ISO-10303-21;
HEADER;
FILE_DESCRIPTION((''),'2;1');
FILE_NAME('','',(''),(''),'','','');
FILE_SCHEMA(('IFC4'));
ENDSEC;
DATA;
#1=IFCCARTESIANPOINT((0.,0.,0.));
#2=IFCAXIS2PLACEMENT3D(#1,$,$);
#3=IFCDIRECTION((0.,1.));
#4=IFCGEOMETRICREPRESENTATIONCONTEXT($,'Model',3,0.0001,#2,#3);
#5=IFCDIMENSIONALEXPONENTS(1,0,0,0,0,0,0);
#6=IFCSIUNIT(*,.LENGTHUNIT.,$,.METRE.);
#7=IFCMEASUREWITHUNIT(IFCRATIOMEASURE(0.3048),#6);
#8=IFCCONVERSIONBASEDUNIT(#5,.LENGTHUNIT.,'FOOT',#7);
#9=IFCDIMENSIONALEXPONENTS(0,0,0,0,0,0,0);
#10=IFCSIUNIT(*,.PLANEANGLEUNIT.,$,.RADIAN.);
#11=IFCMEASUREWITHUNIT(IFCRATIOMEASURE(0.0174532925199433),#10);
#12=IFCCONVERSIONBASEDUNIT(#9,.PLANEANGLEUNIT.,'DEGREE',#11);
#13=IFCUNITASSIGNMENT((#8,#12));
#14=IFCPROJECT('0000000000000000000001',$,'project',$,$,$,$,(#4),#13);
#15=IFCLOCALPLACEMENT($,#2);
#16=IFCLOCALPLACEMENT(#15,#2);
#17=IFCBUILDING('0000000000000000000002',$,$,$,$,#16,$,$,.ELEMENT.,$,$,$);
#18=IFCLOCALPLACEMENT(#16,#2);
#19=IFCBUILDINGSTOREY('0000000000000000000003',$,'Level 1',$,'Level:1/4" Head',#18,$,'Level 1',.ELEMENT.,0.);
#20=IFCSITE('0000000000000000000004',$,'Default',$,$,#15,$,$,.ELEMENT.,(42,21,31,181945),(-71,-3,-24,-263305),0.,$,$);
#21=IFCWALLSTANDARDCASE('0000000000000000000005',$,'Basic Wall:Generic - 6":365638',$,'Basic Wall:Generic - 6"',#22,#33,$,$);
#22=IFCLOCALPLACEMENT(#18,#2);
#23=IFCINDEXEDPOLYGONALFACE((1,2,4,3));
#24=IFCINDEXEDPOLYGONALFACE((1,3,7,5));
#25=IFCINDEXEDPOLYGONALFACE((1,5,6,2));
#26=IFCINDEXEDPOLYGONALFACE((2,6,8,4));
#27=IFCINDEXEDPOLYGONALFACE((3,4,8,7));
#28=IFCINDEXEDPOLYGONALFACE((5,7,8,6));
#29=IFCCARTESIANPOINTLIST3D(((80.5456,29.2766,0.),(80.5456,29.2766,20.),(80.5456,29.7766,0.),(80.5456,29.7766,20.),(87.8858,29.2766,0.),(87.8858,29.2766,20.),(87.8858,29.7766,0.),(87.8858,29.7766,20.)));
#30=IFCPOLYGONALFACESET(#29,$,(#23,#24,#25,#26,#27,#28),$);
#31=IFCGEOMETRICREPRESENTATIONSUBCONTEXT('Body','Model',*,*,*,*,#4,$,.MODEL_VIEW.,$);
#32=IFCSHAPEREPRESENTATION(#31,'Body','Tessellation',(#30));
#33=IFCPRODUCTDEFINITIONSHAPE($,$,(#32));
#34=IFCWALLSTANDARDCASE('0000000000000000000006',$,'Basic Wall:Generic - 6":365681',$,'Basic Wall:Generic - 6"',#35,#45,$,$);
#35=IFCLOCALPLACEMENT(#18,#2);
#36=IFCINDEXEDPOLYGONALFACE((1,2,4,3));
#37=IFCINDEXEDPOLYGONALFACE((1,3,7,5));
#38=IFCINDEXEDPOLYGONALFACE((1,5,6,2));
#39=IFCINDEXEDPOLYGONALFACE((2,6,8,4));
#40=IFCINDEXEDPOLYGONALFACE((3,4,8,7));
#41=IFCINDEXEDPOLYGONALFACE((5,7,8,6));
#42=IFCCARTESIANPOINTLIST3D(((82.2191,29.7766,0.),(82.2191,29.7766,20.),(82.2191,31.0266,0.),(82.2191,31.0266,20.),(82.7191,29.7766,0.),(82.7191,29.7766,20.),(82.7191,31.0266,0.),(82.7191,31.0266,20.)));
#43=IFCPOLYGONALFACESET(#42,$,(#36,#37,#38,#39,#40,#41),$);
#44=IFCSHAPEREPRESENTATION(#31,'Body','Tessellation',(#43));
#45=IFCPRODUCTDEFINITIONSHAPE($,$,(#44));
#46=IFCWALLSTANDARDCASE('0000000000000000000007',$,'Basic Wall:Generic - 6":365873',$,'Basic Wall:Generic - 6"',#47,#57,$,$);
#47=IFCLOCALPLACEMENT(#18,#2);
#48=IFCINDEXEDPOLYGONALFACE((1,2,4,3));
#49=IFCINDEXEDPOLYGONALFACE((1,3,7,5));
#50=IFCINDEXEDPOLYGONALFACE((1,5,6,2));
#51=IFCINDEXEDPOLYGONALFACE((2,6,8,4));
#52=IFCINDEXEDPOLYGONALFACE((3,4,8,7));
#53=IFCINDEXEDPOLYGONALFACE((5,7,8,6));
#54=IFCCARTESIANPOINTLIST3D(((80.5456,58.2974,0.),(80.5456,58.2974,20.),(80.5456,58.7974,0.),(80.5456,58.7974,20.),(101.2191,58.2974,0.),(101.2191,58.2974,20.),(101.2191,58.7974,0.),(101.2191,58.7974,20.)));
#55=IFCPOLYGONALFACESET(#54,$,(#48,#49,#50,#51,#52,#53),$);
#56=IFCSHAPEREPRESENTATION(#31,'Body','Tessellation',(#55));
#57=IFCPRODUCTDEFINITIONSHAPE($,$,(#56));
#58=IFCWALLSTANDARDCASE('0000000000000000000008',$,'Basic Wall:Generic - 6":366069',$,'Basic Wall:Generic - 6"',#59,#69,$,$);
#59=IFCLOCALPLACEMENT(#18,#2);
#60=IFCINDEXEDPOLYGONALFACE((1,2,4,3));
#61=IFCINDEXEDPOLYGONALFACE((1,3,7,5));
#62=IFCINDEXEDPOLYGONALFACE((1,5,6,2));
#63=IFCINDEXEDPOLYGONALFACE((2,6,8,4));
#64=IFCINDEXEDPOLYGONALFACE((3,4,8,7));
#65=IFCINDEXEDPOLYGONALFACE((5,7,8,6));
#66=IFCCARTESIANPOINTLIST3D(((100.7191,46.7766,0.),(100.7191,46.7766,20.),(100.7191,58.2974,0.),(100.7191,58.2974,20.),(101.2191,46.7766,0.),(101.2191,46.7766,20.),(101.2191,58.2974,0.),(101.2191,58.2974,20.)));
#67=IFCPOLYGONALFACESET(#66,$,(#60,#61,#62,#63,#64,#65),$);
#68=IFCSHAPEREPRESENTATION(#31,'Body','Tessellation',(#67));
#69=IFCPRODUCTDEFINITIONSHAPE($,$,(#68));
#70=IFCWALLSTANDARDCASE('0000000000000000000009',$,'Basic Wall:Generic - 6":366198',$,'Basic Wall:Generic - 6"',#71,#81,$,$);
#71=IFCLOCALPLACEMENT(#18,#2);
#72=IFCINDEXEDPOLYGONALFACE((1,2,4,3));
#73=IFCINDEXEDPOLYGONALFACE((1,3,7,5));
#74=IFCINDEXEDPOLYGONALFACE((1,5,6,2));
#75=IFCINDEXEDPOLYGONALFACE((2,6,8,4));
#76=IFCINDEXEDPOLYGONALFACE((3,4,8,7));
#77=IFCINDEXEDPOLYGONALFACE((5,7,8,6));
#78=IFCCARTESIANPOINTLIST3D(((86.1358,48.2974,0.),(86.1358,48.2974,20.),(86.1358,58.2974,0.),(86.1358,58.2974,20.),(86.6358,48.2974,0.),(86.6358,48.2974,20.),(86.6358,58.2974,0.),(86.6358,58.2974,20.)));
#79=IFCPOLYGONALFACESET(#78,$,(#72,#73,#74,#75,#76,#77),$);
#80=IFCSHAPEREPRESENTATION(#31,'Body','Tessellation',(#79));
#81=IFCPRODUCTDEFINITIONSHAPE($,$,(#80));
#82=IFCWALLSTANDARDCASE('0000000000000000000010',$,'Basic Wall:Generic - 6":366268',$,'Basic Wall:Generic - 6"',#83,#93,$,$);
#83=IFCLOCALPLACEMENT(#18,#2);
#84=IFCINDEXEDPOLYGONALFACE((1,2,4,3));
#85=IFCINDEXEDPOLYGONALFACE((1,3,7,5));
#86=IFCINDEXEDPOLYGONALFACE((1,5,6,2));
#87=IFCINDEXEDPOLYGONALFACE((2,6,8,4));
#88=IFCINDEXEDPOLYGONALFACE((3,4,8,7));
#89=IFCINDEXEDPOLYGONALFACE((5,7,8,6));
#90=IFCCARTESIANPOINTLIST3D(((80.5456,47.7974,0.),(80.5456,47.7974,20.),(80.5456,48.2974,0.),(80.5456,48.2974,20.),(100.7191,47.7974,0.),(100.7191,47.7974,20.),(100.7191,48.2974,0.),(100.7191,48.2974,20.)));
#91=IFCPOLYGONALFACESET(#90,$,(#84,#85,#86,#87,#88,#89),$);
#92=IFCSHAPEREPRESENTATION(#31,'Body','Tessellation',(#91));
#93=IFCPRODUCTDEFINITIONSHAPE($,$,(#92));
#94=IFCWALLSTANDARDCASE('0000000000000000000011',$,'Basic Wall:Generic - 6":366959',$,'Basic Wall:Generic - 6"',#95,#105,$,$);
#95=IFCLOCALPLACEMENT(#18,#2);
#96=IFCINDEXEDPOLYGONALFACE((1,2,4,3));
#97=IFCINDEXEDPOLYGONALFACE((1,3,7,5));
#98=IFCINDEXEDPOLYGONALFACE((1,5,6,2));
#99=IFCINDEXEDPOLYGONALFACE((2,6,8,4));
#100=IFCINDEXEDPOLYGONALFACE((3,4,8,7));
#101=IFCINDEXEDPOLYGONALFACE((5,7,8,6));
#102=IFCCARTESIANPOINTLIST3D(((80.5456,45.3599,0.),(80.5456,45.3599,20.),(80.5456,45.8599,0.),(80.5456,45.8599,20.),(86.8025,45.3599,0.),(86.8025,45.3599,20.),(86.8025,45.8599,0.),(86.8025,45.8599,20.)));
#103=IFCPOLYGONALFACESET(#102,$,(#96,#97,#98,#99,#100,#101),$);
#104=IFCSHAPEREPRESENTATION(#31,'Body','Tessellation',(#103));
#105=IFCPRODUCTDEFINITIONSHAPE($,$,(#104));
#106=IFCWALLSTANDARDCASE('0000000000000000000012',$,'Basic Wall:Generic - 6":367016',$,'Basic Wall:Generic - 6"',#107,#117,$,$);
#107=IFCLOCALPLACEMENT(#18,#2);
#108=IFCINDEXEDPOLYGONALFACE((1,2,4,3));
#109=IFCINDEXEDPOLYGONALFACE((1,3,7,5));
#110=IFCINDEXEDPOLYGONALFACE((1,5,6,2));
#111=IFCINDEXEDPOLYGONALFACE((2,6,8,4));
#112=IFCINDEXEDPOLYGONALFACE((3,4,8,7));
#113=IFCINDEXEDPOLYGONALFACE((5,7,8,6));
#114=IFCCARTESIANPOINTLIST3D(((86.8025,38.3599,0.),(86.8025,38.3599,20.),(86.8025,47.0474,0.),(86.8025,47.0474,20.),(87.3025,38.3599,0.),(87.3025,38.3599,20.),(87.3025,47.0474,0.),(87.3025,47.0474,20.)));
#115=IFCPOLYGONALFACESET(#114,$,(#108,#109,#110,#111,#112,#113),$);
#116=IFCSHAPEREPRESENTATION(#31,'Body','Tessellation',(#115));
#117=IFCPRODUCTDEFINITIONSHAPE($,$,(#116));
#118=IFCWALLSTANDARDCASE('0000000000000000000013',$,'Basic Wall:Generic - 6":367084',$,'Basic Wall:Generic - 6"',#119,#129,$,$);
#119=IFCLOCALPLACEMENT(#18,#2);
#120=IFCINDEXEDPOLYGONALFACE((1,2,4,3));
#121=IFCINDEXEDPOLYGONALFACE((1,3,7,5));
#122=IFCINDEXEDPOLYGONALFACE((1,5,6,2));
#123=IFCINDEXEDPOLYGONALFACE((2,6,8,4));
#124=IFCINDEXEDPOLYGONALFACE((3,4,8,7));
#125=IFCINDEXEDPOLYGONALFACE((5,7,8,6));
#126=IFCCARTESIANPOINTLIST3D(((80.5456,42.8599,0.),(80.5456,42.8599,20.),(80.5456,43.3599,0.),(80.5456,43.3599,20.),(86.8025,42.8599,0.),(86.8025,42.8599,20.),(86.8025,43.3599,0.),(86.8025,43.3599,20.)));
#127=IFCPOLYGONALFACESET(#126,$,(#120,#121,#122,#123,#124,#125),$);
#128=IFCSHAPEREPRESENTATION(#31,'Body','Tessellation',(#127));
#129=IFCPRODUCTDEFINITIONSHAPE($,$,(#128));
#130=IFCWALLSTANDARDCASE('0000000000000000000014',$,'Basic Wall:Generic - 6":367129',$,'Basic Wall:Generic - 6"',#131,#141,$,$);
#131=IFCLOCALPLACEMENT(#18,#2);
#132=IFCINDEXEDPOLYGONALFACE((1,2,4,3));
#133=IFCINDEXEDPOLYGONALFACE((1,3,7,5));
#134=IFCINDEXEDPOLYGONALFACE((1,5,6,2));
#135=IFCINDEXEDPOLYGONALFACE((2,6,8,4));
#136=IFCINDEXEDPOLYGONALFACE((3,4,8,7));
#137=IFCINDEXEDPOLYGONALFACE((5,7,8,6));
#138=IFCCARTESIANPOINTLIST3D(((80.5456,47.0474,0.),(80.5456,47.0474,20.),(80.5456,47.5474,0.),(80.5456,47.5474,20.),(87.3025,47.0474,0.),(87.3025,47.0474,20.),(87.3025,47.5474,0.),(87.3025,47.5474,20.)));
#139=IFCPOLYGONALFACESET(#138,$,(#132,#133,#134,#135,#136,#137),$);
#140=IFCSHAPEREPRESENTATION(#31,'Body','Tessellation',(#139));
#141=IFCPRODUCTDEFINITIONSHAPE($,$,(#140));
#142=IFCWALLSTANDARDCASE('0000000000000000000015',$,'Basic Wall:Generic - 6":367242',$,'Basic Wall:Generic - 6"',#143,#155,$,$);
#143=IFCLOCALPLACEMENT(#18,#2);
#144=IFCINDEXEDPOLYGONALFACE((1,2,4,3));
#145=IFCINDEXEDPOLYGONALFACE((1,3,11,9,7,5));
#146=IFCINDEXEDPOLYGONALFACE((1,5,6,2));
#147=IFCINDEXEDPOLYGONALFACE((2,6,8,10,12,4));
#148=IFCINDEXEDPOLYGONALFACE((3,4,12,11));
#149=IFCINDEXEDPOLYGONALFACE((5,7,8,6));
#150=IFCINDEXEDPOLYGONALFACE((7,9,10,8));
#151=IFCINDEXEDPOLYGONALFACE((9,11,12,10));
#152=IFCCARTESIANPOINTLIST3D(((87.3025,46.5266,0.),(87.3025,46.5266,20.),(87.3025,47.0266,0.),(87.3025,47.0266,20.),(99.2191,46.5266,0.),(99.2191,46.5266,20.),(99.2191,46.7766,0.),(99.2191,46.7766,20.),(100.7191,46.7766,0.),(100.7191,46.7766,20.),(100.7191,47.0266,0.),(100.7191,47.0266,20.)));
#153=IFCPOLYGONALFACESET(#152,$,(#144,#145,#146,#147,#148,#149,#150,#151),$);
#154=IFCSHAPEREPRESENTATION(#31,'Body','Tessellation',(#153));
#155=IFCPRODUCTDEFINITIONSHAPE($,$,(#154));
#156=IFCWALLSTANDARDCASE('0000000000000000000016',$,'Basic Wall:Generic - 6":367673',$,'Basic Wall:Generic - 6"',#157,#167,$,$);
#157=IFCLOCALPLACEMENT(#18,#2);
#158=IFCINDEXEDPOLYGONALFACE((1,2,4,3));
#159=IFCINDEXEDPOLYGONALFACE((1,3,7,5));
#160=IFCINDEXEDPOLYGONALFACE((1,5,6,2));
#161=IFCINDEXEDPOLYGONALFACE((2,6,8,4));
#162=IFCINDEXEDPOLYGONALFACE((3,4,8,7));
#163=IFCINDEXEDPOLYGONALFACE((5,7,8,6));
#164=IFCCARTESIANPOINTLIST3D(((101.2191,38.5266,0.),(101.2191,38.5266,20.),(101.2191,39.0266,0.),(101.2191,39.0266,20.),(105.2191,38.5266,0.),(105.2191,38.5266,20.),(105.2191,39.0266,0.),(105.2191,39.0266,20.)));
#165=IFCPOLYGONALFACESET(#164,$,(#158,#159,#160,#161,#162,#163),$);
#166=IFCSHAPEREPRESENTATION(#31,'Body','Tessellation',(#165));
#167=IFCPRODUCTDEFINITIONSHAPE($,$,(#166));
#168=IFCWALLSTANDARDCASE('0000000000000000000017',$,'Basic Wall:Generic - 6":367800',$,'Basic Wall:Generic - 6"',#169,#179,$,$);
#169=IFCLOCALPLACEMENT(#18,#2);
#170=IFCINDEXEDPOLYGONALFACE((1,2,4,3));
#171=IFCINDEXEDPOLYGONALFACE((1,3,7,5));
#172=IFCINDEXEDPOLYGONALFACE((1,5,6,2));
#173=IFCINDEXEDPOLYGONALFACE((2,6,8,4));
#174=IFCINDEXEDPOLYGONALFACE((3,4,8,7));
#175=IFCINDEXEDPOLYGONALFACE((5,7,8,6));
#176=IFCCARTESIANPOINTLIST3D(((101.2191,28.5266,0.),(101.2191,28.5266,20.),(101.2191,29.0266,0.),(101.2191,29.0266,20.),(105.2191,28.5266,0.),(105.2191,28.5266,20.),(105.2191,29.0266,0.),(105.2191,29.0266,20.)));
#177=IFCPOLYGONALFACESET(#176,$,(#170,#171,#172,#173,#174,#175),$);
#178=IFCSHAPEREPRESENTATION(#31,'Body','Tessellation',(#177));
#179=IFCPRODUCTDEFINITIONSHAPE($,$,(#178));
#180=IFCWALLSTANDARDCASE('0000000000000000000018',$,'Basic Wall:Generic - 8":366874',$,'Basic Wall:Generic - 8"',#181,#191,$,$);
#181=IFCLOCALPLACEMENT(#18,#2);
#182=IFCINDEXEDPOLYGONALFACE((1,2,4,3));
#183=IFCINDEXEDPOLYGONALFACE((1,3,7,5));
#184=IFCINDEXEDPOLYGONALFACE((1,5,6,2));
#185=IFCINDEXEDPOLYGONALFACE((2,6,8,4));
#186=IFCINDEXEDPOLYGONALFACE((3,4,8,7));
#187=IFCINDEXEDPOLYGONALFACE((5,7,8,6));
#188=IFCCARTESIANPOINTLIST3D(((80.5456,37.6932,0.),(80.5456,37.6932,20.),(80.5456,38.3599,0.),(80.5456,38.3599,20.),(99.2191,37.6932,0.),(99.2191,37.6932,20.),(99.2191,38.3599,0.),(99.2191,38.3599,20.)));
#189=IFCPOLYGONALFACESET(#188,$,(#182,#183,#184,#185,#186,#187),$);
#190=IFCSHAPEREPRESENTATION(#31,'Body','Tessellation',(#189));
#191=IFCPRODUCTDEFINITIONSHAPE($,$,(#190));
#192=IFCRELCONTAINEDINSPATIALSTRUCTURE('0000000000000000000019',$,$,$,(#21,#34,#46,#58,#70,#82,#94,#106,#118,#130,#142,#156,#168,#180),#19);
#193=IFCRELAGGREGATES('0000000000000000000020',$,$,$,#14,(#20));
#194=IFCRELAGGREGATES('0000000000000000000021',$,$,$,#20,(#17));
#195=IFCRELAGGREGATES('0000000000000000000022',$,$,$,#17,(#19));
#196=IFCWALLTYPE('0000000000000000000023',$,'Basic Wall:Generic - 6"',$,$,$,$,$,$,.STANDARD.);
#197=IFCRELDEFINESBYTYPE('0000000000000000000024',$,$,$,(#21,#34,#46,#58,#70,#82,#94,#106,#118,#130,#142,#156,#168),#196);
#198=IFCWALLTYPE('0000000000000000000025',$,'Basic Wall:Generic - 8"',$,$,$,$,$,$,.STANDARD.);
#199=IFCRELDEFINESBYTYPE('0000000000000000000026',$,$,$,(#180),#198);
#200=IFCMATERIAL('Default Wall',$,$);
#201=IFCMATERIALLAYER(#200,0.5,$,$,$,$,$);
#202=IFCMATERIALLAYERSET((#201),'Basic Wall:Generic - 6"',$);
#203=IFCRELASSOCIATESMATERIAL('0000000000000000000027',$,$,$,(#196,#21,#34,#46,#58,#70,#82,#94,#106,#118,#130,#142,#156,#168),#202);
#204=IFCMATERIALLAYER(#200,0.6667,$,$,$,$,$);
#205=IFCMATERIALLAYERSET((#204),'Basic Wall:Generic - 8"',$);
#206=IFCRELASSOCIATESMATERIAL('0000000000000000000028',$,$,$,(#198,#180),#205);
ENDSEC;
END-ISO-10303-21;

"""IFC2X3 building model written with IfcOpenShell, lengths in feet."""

from ifc_helpers import new_model, entity, si_unit, converted_unit, direction, frame, frame_2d, origin, place, context, subcontext, project, spatial, polyline, rectangle, outline, extrude, material, layer, layer_set, layer_usage, type_object, element, save


model = new_model("IFC2X3")

# Units and contexts
model_context = context("Model", 3, precision=0.0001, world=origin(), true_north=direction((0.0, 1.0)))
body_context = subcontext(model_context, "Body", "Model", "MODEL_VIEW")
ifc_project = project(units=[converted_unit("LENGTHUNIT", "FOOT", entity("IfcRatioMeasure", 0.3048), si_unit("LENGTHUNIT", "METRE"), dimensions=[1, 0, 0, 0, 0, 0, 0]), converted_unit("PLANEANGLEUNIT", "DEGREE", entity("IfcRatioMeasure", 0.0174532925199433), si_unit("PLANEANGLEUNIT", "RADIAN"), dimensions=[0, 0, 0, 0, 0, 0, 0])], contexts=[model_context])

# Site, building, storey
site_placement = place(None, origin())
site = spatial("IfcSite", under=ifc_project, at=site_placement, Name="Default", CompositionType="ELEMENT", RefLatitude=(42, 21, 31, 181945), RefLongitude=(-71, -3, -24, -263305), RefElevation=0.0)
building_placement = place(site_placement, origin())
building = spatial("IfcBuilding", under=site, at=building_placement, CompositionType="ELEMENT")
storey_placement = place(building_placement, origin())
storey = spatial("IfcBuildingStorey", under=building, at=storey_placement, Name="Level 1", ObjectType="Level:1/4\" Head", LongName="Level 1", CompositionType="ELEMENT", Elevation=0.0)

# Walls
ifc_material = material(Name="Default Wall")
ifc_layer_1 = layer(ifc_material, 0.5)
ifc_layer_set_1 = layer_set([ifc_layer_1], Name="Basic Wall:Generic - 6\"")
wall_type_1 = type_object("IfcWallType", Name="Basic Wall:Generic - 6\"", PredefinedType="STANDARD", material=ifc_layer_set_1)
ifc_layer_usage_1 = layer_usage(ifc_layer_set_1, "AXIS2", "NEGATIVE", 0.25)
wall_1_placement = place(storey_placement, frame((80.5456, 29.5266, 0.0)))
element("IfcWallStandardCase", 1, at=wall_1_placement, inside=storey, type_object=wall_type_1, material=ifc_layer_usage_1, Name="Basic Wall:Generic - 6\":365638", ObjectType="Basic Wall:Generic - 6\"", context=body_context, shape_type="SweptSolid", body=[
    extrude(rectangle(XDim=7.3402, YDim=0.5, at=frame_2d((3.6701, 0.0), x_axis=(-1.0, 0.0))), origin(), (0.0, 0.0, 1.0), 20.0),
])
ifc_layer_usage_2 = layer_usage(ifc_layer_set_1, "AXIS2", "NEGATIVE", 0.25)
wall_2_placement = place(storey_placement, frame((82.4691, 29.7766, 0.0), z_axis=(0.0, 0.0, 1.0), x_axis=(0.0, 1.0, 0.0)))
element("IfcWallStandardCase", 2, at=wall_2_placement, inside=storey, type_object=wall_type_1, material=ifc_layer_usage_2, Name="Basic Wall:Generic - 6\":365681", ObjectType="Basic Wall:Generic - 6\"", context=body_context, shape_type="SweptSolid", body=[
    extrude(rectangle(XDim=1.25, YDim=0.5, at=frame_2d((0.625, 0.0), x_axis=(-1.0, 0.0))), origin(), (0.0, 0.0, 1.0), 20.0),
])
ifc_layer_usage_3 = layer_usage(ifc_layer_set_1, "AXIS2", "NEGATIVE", 0.25)
wall_3_placement = place(storey_placement, frame((80.5456, 58.5474, 0.0)))
element("IfcWallStandardCase", 3, at=wall_3_placement, inside=storey, type_object=wall_type_1, material=ifc_layer_usage_3, Name="Basic Wall:Generic - 6\":365873", ObjectType="Basic Wall:Generic - 6\"", context=body_context, shape_type="SweptSolid", body=[
    extrude(rectangle(XDim=20.6735, YDim=0.5, at=frame_2d((10.3368, 0.0), x_axis=(-1.0, 0.0))), origin(), (0.0, 0.0, 1.0), 20.0),
])
ifc_layer_usage_4 = layer_usage(ifc_layer_set_1, "AXIS2", "NEGATIVE", 0.25)
wall_4_placement = place(storey_placement, frame((100.9691, 58.2974, 0.0), z_axis=(0.0, 0.0, 1.0), x_axis=(0.0, -1.0, 0.0)))
element("IfcWallStandardCase", 4, at=wall_4_placement, inside=storey, type_object=wall_type_1, material=ifc_layer_usage_4, Name="Basic Wall:Generic - 6\":366069", ObjectType="Basic Wall:Generic - 6\"", context=body_context, shape_type="SweptSolid", body=[
    extrude(rectangle(XDim=11.5208, YDim=0.5, at=frame_2d((5.7604, 0.0), x_axis=(-1.0, 0.0))), origin(), (0.0, 0.0, 1.0), 20.0),
])
ifc_layer_usage_5 = layer_usage(ifc_layer_set_1, "AXIS2", "NEGATIVE", 0.25)
wall_5_placement = place(storey_placement, frame((86.3858, 58.2974, 0.0), z_axis=(0.0, 0.0, 1.0), x_axis=(0.0, -1.0, 0.0)))
element("IfcWallStandardCase", 5, at=wall_5_placement, inside=storey, type_object=wall_type_1, material=ifc_layer_usage_5, Name="Basic Wall:Generic - 6\":366198", ObjectType="Basic Wall:Generic - 6\"", context=body_context, shape_type="SweptSolid", body=[
    extrude(rectangle(XDim=10.0, YDim=0.5, at=frame_2d((5.0, 0.0), x_axis=(-1.0, 0.0))), origin(), (0.0, 0.0, 1.0), 20.0),
])
ifc_layer_usage_6 = layer_usage(ifc_layer_set_1, "AXIS2", "NEGATIVE", 0.25)
wall_6_placement = place(storey_placement, frame((100.7191, 48.0474, 0.0), z_axis=(0.0, 0.0, 1.0), x_axis=(-1.0, 0.0, 0.0)))
element("IfcWallStandardCase", 6, at=wall_6_placement, inside=storey, type_object=wall_type_1, material=ifc_layer_usage_6, Name="Basic Wall:Generic - 6\":366268", ObjectType="Basic Wall:Generic - 6\"", context=body_context, shape_type="SweptSolid", body=[
    extrude(rectangle(XDim=20.1735, YDim=0.5, at=frame_2d((10.0868, 0.0), x_axis=(-1.0, 0.0))), origin(), (0.0, 0.0, 1.0), 20.0),
])
ifc_layer_usage_7 = layer_usage(ifc_layer_set_1, "AXIS2", "NEGATIVE", 0.25)
wall_7_placement = place(storey_placement, frame((80.5456, 45.6099, 0.0)))
element("IfcWallStandardCase", 7, at=wall_7_placement, inside=storey, type_object=wall_type_1, material=ifc_layer_usage_7, Name="Basic Wall:Generic - 6\":366959", ObjectType="Basic Wall:Generic - 6\"", context=body_context, shape_type="SweptSolid", body=[
    extrude(rectangle(XDim=6.2568, YDim=0.5, at=frame_2d((3.1284, 0.0), x_axis=(-1.0, 0.0))), origin(), (0.0, 0.0, 1.0), 20.0),
])
ifc_layer_usage_8 = layer_usage(ifc_layer_set_1, "AXIS2", "NEGATIVE", 0.25)
wall_8_placement = place(storey_placement, frame((87.0525, 47.0474, 0.0), z_axis=(0.0, 0.0, 1.0), x_axis=(0.0, -1.0, 0.0)))
element("IfcWallStandardCase", 8, at=wall_8_placement, inside=storey, type_object=wall_type_1, material=ifc_layer_usage_8, Name="Basic Wall:Generic - 6\":367016", ObjectType="Basic Wall:Generic - 6\"", context=body_context, shape_type="SweptSolid", body=[
    extrude(rectangle(XDim=8.6875, YDim=0.5, at=frame_2d((4.3437, 0.0), x_axis=(-1.0, 0.0))), origin(), (0.0, 0.0, 1.0), 20.0),
])
ifc_layer_usage_9 = layer_usage(ifc_layer_set_1, "AXIS2", "NEGATIVE", 0.25)
wall_9_placement = place(storey_placement, frame((86.8025, 43.1099, 0.0), z_axis=(0.0, 0.0, 1.0), x_axis=(-1.0, 0.0, 0.0)))
element("IfcWallStandardCase", 9, at=wall_9_placement, inside=storey, type_object=wall_type_1, material=ifc_layer_usage_9, Name="Basic Wall:Generic - 6\":367084", ObjectType="Basic Wall:Generic - 6\"", context=body_context, shape_type="SweptSolid", body=[
    extrude(rectangle(XDim=6.2568, YDim=0.5, at=frame_2d((3.1284, 0.0), x_axis=(-1.0, 0.0))), origin(), (0.0, 0.0, 1.0), 20.0),
])
ifc_layer_usage_10 = layer_usage(ifc_layer_set_1, "AXIS2", "NEGATIVE", 0.25)
wall_10_placement = place(storey_placement, frame((80.5456, 47.2974, 0.0)))
element("IfcWallStandardCase", 10, at=wall_10_placement, inside=storey, type_object=wall_type_1, material=ifc_layer_usage_10, Name="Basic Wall:Generic - 6\":367129", ObjectType="Basic Wall:Generic - 6\"", context=body_context, shape_type="SweptSolid", body=[
    extrude(rectangle(XDim=6.7568, YDim=0.5, at=frame_2d((3.3784, 0.0), x_axis=(-1.0, 0.0))), origin(), (0.0, 0.0, 1.0), 20.0),
])
ifc_layer_usage_11 = layer_usage(ifc_layer_set_1, "AXIS2", "NEGATIVE", 0.25)
wall_11_placement = place(storey_placement, frame((100.7191, 46.7766, 0.0), z_axis=(0.0, 0.0, 1.0), x_axis=(-1.0, 0.0, 0.0)))
element("IfcWallStandardCase", 11, at=wall_11_placement, inside=storey, type_object=wall_type_1, material=ifc_layer_usage_11, Name="Basic Wall:Generic - 6\":367242", ObjectType="Basic Wall:Generic - 6\"", context=body_context, shape_type="SweptSolid", body=[
    extrude(outline(polyline([(13.4167, -0.25), (13.4167, 0.25), (1.5, 0.25), (1.5, 0.0), (0.0, 0.0), (0.0, -0.25), (13.4167, -0.25)])), origin(), (0.0, 0.0, 1.0), 20.0),
])
ifc_layer_usage_12 = layer_usage(ifc_layer_set_1, "AXIS2", "NEGATIVE", 0.25)
wall_12_placement = place(storey_placement, frame((101.2191, 38.7766, 0.0)))
element("IfcWallStandardCase", 12, at=wall_12_placement, inside=storey, type_object=wall_type_1, material=ifc_layer_usage_12, Name="Basic Wall:Generic - 6\":367673", ObjectType="Basic Wall:Generic - 6\"", context=body_context, shape_type="SweptSolid", body=[
    extrude(rectangle(XDim=4.0, YDim=0.5, at=frame_2d((2.0, 0.0), x_axis=(-1.0, 0.0))), origin(), (0.0, 0.0, 1.0), 20.0),
])
ifc_layer_usage_13 = layer_usage(ifc_layer_set_1, "AXIS2", "NEGATIVE", 0.25)
wall_13_placement = place(storey_placement, frame((101.2191, 28.7766, 0.0)))
element("IfcWallStandardCase", 13, at=wall_13_placement, inside=storey, type_object=wall_type_1, material=ifc_layer_usage_13, Name="Basic Wall:Generic - 6\":367800", ObjectType="Basic Wall:Generic - 6\"", context=body_context, shape_type="SweptSolid", body=[
    extrude(rectangle(XDim=4.0, YDim=0.5, at=frame_2d((2.0, 0.0), x_axis=(-1.0, 0.0))), origin(), (0.0, 0.0, 1.0), 20.0),
])
ifc_layer_2 = layer(ifc_material, 0.6667)
ifc_layer_set_2 = layer_set([ifc_layer_2], Name="Basic Wall:Generic - 8\"")
ifc_layer_usage_14 = layer_usage(ifc_layer_set_2, "AXIS2", "NEGATIVE", 0.3333)
wall_type_2 = type_object("IfcWallType", Name="Basic Wall:Generic - 8\"", PredefinedType="STANDARD", material=ifc_layer_set_2)
wall_14_placement = place(storey_placement, frame((80.5456, 38.0266, 0.0)))
element("IfcWallStandardCase", 14, at=wall_14_placement, inside=storey, type_object=wall_type_2, material=ifc_layer_usage_14, Name="Basic Wall:Generic - 8\":366874", ObjectType="Basic Wall:Generic - 8\"", context=body_context, shape_type="SweptSolid", body=[
    extrude(rectangle(XDim=18.6735, YDim=0.6667, at=frame_2d((9.3368, 0.0), x_axis=(-1.0, 0.0))), origin(), (0.0, 0.0, 1.0), 20.0),
])

save(model, "model.ifc")
